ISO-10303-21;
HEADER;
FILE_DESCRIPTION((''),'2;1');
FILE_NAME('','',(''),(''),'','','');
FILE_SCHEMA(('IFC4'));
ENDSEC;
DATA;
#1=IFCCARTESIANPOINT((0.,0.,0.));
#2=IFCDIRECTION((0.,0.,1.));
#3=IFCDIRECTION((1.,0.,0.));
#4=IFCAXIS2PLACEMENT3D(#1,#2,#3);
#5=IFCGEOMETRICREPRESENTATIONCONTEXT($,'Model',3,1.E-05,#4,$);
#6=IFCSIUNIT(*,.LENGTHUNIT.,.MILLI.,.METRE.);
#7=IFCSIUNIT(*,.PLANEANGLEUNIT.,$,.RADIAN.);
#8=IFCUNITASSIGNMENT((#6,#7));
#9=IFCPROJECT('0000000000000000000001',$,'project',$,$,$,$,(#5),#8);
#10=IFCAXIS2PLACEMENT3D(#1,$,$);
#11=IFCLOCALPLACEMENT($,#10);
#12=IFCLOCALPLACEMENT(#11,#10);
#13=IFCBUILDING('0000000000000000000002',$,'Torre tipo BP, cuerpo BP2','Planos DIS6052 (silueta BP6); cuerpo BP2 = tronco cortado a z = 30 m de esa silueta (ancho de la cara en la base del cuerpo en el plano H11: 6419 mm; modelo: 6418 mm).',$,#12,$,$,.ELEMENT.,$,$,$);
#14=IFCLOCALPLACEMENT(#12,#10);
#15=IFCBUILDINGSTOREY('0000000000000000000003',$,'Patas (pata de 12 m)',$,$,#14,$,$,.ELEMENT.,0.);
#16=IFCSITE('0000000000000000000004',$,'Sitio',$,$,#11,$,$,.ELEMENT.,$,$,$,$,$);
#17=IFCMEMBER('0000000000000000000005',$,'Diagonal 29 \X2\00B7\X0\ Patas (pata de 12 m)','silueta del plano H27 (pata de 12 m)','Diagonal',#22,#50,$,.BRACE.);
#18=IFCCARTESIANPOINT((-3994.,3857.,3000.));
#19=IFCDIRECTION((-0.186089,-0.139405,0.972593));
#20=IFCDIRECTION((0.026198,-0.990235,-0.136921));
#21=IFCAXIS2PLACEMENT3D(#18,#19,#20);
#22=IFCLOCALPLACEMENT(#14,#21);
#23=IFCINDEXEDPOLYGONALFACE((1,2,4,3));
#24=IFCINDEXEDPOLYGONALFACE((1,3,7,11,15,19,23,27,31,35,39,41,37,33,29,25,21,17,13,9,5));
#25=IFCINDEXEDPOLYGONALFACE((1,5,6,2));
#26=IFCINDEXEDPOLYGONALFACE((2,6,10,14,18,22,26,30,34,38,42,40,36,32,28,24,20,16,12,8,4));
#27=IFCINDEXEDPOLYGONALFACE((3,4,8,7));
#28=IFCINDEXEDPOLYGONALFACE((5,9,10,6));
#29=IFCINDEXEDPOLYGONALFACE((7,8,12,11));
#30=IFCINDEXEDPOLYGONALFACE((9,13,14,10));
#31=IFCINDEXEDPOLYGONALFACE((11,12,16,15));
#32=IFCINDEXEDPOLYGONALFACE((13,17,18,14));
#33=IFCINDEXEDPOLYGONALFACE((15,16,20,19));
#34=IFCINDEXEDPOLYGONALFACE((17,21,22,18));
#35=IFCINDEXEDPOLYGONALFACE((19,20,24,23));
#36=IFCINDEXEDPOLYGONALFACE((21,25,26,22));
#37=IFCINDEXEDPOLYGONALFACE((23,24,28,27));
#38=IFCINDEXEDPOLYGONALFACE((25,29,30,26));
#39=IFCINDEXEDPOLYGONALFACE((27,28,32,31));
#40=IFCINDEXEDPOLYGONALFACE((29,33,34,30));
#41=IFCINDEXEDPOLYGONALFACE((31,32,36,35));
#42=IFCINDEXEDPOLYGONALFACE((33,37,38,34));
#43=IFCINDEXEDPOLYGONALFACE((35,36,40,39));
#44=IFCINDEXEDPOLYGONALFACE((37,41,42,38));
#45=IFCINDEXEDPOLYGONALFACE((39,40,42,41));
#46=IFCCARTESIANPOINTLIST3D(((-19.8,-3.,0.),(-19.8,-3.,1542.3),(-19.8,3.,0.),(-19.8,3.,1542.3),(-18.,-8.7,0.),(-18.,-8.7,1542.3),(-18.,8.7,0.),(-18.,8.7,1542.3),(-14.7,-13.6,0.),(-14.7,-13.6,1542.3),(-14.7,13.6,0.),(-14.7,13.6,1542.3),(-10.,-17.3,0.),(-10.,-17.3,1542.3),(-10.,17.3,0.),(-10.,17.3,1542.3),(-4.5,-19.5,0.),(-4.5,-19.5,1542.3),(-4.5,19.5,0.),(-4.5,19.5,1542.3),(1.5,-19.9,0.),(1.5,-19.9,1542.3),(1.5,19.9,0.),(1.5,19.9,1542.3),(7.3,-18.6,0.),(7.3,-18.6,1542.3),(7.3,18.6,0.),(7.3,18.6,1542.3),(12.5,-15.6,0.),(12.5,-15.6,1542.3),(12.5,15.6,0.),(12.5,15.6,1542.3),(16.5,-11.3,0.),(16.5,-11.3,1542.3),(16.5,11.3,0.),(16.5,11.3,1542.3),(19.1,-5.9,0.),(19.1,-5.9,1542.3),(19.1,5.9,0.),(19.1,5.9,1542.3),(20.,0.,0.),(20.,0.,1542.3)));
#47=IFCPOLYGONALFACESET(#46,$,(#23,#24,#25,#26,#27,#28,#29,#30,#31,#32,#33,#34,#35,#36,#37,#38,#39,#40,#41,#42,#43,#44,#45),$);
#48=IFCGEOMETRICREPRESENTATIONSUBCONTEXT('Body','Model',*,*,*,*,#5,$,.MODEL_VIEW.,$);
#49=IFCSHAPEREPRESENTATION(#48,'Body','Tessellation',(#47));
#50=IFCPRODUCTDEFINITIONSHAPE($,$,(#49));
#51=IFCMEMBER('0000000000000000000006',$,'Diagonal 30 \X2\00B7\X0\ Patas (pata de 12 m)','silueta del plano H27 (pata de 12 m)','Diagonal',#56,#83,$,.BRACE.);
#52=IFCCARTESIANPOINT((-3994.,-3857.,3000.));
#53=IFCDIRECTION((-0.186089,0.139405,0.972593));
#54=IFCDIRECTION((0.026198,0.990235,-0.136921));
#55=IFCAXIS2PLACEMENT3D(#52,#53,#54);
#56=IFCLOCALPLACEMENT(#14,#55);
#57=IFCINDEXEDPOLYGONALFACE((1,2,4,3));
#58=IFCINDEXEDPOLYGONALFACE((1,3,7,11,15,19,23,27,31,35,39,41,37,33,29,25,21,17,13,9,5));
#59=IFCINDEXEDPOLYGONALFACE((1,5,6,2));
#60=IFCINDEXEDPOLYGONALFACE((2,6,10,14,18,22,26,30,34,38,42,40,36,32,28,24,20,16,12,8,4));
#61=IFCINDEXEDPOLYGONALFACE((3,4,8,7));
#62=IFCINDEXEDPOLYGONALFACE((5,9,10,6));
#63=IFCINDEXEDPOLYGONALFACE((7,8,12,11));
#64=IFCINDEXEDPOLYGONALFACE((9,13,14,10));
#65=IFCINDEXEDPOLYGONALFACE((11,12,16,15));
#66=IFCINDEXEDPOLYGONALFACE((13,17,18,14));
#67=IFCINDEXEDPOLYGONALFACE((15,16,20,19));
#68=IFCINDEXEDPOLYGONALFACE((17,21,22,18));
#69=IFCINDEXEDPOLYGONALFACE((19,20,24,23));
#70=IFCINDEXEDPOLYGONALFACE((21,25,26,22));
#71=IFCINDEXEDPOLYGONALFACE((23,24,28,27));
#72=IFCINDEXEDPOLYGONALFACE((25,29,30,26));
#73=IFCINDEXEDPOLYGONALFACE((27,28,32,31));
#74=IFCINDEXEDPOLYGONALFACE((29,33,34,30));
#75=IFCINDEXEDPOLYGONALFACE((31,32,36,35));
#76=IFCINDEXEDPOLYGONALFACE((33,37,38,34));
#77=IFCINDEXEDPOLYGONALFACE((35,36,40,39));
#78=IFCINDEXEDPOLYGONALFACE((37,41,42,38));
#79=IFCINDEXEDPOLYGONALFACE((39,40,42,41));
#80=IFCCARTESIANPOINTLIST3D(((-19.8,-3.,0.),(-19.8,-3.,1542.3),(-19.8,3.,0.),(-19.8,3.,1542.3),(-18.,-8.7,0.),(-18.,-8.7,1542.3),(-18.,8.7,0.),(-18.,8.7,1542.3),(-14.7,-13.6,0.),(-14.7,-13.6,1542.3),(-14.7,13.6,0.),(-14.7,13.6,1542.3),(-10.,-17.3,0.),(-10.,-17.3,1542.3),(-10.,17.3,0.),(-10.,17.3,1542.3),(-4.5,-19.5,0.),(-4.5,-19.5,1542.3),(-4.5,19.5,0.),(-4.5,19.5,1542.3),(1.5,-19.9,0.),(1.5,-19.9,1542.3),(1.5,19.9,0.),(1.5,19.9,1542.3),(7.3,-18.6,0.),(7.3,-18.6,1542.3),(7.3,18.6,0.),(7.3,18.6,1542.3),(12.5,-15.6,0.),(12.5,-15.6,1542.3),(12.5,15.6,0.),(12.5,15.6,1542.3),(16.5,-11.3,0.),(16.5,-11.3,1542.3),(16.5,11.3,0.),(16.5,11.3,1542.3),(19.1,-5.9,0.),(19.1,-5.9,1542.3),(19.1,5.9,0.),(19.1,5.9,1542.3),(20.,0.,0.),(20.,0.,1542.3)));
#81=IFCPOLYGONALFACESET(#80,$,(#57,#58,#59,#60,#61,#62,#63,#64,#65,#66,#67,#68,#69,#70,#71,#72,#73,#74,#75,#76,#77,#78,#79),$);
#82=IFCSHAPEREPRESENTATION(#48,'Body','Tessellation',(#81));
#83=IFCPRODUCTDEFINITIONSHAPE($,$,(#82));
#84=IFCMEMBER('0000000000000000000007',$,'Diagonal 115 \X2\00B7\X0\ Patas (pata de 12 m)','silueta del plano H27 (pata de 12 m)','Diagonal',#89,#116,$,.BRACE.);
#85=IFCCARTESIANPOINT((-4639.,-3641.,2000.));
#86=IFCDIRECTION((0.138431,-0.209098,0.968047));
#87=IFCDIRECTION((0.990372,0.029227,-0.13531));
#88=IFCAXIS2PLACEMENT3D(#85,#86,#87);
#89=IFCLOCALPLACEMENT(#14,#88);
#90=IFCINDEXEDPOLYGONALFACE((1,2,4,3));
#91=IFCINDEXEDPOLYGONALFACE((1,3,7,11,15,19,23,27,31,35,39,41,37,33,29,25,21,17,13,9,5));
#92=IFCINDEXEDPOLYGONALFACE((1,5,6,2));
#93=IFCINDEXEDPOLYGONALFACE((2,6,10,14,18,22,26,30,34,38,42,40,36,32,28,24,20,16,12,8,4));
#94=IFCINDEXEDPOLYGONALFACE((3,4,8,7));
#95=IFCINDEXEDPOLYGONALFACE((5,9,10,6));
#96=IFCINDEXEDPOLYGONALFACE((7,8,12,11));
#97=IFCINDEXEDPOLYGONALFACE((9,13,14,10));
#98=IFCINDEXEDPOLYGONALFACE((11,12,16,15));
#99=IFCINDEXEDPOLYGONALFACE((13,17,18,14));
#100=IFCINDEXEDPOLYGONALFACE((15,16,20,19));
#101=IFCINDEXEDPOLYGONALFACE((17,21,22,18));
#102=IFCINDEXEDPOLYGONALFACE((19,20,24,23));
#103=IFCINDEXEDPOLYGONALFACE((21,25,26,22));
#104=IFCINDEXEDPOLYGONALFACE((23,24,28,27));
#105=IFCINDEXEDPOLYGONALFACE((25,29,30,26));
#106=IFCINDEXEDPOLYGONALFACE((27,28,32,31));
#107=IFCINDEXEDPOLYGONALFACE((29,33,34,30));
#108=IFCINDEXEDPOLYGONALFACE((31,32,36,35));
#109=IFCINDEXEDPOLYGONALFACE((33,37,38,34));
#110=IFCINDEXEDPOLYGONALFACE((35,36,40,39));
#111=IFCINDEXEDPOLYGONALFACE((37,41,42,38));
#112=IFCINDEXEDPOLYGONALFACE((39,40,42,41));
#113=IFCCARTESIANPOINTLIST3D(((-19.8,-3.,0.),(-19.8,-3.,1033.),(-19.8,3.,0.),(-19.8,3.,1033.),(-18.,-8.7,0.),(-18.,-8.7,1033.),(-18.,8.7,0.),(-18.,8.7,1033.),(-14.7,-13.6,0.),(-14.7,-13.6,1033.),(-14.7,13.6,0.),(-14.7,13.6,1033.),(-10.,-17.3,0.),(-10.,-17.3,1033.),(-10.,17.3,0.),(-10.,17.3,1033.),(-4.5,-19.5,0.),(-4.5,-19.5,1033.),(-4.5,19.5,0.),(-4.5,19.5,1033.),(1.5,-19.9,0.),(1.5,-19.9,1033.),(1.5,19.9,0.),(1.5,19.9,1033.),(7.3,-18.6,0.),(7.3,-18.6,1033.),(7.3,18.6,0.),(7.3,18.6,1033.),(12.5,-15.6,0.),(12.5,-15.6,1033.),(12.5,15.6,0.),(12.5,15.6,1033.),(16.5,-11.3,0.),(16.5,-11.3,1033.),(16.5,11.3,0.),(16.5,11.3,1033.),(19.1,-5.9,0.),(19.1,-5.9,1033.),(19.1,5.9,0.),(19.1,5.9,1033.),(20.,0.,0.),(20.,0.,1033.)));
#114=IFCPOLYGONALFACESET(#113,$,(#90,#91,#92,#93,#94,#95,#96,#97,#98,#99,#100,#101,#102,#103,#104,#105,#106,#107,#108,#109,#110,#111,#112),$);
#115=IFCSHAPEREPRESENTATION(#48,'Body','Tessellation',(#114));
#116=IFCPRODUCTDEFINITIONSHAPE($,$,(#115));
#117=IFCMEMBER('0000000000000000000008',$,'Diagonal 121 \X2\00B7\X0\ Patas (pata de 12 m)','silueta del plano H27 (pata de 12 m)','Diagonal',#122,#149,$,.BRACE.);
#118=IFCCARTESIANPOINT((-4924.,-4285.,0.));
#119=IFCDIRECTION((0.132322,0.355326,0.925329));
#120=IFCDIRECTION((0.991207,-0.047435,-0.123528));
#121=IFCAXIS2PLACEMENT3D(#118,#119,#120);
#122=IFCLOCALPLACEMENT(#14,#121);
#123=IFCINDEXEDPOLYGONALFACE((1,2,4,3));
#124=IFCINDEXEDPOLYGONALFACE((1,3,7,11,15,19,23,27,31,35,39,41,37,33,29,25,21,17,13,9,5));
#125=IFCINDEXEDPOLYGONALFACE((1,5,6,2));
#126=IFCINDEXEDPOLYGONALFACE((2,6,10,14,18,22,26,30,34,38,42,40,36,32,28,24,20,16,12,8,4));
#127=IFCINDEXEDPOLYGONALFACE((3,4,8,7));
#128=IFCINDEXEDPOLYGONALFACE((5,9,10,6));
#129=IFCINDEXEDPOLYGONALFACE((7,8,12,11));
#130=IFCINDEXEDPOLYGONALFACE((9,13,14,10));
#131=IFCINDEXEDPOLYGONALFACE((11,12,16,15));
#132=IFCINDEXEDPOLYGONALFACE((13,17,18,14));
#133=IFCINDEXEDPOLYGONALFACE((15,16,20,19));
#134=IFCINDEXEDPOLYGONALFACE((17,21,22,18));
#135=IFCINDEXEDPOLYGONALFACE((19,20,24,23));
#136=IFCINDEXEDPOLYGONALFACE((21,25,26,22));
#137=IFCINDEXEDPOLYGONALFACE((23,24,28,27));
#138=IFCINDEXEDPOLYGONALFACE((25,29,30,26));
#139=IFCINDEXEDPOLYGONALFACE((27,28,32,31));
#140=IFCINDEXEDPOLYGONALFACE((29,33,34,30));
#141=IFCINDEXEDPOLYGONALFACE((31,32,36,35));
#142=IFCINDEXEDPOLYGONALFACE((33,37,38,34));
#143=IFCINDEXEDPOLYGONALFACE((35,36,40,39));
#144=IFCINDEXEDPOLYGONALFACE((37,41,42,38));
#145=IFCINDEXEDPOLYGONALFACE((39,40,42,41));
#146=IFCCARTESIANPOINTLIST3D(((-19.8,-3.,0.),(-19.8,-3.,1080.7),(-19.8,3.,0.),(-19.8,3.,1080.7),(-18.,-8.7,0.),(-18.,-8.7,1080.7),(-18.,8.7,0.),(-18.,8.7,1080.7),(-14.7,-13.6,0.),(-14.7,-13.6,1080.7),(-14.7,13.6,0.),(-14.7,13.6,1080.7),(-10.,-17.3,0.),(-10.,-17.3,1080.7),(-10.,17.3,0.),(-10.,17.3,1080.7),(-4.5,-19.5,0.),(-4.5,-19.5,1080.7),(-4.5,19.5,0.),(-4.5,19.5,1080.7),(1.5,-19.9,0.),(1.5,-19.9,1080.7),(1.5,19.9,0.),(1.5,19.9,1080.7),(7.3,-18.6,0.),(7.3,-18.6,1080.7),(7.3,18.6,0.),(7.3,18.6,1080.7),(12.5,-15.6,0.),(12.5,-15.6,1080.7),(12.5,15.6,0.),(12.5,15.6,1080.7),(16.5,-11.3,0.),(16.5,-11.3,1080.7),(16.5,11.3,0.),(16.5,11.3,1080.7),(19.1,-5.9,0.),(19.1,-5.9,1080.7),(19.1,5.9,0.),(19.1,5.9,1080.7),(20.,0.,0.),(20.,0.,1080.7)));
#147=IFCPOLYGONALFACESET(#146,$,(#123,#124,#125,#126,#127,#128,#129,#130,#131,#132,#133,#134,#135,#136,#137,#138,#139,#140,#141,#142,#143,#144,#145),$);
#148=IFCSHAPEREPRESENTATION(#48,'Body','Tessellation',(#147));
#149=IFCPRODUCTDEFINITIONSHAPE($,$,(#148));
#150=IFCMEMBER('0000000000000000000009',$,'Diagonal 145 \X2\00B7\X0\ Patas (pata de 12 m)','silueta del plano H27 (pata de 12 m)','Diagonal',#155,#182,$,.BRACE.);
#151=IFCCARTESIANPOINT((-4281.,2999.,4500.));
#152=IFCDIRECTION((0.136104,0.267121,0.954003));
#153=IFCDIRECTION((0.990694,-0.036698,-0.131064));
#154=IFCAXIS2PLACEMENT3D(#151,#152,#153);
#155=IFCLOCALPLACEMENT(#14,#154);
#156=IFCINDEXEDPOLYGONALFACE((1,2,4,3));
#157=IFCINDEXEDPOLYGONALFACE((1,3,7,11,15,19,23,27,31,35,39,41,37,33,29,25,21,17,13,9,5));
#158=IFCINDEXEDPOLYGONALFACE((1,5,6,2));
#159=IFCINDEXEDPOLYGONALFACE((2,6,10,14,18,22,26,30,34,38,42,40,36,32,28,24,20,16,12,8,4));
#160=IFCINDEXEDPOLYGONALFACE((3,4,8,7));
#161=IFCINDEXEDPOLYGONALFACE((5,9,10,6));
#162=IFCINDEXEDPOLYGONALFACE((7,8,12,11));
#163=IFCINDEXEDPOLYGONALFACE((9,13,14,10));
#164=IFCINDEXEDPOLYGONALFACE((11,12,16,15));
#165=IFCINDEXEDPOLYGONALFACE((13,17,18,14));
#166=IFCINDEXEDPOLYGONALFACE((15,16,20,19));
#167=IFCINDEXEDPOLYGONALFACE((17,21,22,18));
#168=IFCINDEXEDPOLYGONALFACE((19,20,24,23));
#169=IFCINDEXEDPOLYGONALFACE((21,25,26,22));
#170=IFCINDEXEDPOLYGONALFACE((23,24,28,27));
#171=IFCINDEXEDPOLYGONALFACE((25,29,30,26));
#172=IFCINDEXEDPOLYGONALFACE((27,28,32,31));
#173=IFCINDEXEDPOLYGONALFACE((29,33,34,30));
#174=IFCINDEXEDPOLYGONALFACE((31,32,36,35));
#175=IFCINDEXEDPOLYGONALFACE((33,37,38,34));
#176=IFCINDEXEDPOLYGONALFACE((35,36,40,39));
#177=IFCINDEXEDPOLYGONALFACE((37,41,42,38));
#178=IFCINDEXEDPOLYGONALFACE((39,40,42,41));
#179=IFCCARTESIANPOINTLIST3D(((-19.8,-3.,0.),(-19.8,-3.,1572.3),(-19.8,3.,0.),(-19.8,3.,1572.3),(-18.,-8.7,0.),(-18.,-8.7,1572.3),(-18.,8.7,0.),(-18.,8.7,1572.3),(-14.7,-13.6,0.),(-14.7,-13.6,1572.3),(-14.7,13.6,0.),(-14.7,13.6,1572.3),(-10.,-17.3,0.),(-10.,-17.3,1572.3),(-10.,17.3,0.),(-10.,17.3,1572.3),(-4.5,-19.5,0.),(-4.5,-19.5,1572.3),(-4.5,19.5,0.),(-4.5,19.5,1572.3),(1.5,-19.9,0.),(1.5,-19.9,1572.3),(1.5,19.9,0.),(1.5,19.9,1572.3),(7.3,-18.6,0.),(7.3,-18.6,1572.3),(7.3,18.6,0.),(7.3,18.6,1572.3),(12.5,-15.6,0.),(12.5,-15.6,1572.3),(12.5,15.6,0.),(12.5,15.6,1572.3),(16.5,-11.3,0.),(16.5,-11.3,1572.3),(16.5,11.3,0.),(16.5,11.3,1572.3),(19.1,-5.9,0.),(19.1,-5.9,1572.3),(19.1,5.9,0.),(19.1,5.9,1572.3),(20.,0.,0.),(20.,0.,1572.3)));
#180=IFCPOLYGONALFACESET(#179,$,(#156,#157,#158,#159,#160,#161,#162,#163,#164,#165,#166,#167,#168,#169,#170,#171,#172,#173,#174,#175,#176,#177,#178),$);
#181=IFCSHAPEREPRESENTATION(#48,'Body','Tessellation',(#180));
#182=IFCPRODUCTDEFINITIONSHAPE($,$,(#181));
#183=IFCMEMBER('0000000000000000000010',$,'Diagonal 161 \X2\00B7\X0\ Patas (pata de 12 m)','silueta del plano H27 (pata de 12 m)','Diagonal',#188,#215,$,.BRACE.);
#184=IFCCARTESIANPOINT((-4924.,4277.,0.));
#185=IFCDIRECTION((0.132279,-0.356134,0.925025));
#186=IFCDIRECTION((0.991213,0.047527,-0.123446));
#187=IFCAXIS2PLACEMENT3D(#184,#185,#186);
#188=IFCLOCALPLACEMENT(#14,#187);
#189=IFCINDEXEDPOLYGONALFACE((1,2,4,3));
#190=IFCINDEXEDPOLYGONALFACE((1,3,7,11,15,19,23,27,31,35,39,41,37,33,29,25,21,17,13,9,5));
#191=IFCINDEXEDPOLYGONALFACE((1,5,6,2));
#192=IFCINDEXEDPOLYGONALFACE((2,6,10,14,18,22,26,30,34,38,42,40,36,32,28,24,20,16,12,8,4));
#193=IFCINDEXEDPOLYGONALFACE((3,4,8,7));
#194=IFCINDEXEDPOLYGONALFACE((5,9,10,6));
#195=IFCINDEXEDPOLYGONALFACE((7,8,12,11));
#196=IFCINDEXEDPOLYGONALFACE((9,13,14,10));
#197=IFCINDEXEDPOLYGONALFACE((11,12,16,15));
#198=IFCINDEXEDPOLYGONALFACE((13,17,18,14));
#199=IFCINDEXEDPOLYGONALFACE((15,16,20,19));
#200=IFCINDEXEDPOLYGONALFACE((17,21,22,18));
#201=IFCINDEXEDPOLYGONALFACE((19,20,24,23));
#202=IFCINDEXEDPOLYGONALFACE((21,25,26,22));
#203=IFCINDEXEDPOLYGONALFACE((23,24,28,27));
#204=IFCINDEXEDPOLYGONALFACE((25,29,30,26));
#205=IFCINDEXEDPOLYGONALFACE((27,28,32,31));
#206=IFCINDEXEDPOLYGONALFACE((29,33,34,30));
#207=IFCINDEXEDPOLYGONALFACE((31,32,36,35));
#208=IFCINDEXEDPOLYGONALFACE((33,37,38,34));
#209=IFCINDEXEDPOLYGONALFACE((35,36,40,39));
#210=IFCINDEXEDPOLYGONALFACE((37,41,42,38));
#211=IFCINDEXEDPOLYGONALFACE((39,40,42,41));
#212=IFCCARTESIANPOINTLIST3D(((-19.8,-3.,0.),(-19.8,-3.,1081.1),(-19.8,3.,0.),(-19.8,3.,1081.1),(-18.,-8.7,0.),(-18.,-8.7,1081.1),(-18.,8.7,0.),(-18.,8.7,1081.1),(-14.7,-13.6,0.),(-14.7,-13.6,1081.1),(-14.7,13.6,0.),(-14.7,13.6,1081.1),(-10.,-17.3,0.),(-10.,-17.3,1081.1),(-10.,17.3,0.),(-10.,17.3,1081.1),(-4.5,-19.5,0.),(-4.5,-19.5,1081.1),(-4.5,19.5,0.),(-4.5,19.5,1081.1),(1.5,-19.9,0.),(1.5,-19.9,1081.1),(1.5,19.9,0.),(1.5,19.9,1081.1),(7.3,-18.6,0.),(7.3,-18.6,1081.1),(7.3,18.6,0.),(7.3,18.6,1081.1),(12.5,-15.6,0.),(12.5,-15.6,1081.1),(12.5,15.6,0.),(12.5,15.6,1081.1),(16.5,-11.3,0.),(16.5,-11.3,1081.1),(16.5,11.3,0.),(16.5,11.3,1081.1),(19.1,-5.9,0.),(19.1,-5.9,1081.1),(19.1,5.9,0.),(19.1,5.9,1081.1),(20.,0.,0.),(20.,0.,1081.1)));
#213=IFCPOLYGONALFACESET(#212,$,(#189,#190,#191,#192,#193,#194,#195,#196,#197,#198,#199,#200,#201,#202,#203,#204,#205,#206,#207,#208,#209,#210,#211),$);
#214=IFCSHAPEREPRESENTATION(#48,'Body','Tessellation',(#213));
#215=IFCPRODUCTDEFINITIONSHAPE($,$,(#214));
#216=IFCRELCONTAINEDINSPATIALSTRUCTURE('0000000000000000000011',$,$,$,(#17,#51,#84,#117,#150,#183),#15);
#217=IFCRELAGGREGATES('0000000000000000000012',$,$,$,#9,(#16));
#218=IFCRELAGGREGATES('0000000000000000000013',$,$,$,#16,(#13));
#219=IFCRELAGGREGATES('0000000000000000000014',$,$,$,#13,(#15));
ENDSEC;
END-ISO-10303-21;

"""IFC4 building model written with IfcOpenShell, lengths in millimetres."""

from ifc_helpers import new_model, si_unit, frame, origin, origin_with_axes, place, context, subcontext, project, spatial, circle, extrude, element, save


model = new_model("IFC4")

# Units and contexts
model_context = context("Model", 3, precision=1e-05, world=origin_with_axes())
body_context = subcontext(model_context, "Body", "Model", "MODEL_VIEW")
ifc_project = project(units=[si_unit("LENGTHUNIT", "METRE", prefix="MILLI"), si_unit("PLANEANGLEUNIT", "RADIAN")], contexts=[model_context])

# Site, building, storey
site_placement = place(None, origin())
site = spatial("IfcSite", under=ifc_project, at=site_placement, Name="Sitio", CompositionType="ELEMENT")
building_placement = place(site_placement, origin())
building = spatial("IfcBuilding", under=site, at=building_placement, Name="Torre tipo BP, cuerpo BP2", Description="Planos DIS6052 (silueta BP6); cuerpo BP2 = tronco cortado a z = 30 m de esa silueta (ancho de la cara en la base del cuerpo en el plano H11: 6419 mm; modelo: 6418 mm).", CompositionType="ELEMENT")
storey_placement = place(building_placement, origin())
storey = spatial("IfcBuildingStorey", under=building, at=storey_placement, Name="Patas (pata de 12 m)", CompositionType="ELEMENT", Elevation=0.0)

# Members
for number, where, z_axis, x_axis, name in (
    (1, (-3994.0, 3857.0, 3000.0), (-0.186089, -0.139405, 0.972593), (0.026198, -0.990235, -0.136921), "Diagonal 29 · Patas (pata de 12 m)"),
    (2, (-3994.0, -3857.0, 3000.0), (-0.186089, 0.139405, 0.972593), (0.026198, 0.990235, -0.136921), "Diagonal 30 · Patas (pata de 12 m)"),
):
    element("IfcMember", number, at=place(storey_placement, frame(where, z_axis=z_axis, x_axis=x_axis)), inside=storey, Name=name, Description="silueta del plano H27 (pata de 12 m)", ObjectType="Diagonal", PredefinedType="BRACE", context=body_context, shape_type="SweptSolid", body=[
        extrude(circle(Radius=20.0), None, (0.0, 0.0, 1.0), 1542.3),
    ])
member_1_placement = place(storey_placement, frame((-4639.0, -3641.0, 2000.0), z_axis=(0.138431, -0.209098, 0.968047), x_axis=(0.990372, 0.029227, -0.13531)))
element("IfcMember", 3, at=member_1_placement, inside=storey, Name="Diagonal 115 · Patas (pata de 12 m)", Description="silueta del plano H27 (pata de 12 m)", ObjectType="Diagonal", PredefinedType="BRACE", context=body_context, shape_type="SweptSolid", body=[
    extrude(circle(Radius=20.0), None, (0.0, 0.0, 1.0), 1033.0),
])
member_2_placement = place(storey_placement, frame((-4924.0, -4285.0, 0.0), z_axis=(0.132322, 0.355326, 0.925329), x_axis=(0.991207, -0.047435, -0.123528)))
element("IfcMember", 4, at=member_2_placement, inside=storey, Name="Diagonal 121 · Patas (pata de 12 m)", Description="silueta del plano H27 (pata de 12 m)", ObjectType="Diagonal", PredefinedType="BRACE", context=body_context, shape_type="SweptSolid", body=[
    extrude(circle(Radius=20.0), None, (0.0, 0.0, 1.0), 1080.7),
])
member_3_placement = place(storey_placement, frame((-4281.0, 2999.0, 4500.0), z_axis=(0.136104, 0.267121, 0.954003), x_axis=(0.990694, -0.036698, -0.131064)))
element("IfcMember", 5, at=member_3_placement, inside=storey, Name="Diagonal 145 · Patas (pata de 12 m)", Description="silueta del plano H27 (pata de 12 m)", ObjectType="Diagonal", PredefinedType="BRACE", context=body_context, shape_type="SweptSolid", body=[
    extrude(circle(Radius=20.0), None, (0.0, 0.0, 1.0), 1572.3),
])
member_4_placement = place(storey_placement, frame((-4924.0, 4277.0, 0.0), z_axis=(0.132279, -0.356134, 0.925025), x_axis=(0.991213, 0.047527, -0.123446)))
element("IfcMember", 6, at=member_4_placement, inside=storey, Name="Diagonal 161 · Patas (pata de 12 m)", Description="silueta del plano H27 (pata de 12 m)", ObjectType="Diagonal", PredefinedType="BRACE", context=body_context, shape_type="SweptSolid", body=[
    extrude(circle(Radius=20.0), None, (0.0, 0.0, 1.0), 1081.1),
])

save(model, "model.ifc")
